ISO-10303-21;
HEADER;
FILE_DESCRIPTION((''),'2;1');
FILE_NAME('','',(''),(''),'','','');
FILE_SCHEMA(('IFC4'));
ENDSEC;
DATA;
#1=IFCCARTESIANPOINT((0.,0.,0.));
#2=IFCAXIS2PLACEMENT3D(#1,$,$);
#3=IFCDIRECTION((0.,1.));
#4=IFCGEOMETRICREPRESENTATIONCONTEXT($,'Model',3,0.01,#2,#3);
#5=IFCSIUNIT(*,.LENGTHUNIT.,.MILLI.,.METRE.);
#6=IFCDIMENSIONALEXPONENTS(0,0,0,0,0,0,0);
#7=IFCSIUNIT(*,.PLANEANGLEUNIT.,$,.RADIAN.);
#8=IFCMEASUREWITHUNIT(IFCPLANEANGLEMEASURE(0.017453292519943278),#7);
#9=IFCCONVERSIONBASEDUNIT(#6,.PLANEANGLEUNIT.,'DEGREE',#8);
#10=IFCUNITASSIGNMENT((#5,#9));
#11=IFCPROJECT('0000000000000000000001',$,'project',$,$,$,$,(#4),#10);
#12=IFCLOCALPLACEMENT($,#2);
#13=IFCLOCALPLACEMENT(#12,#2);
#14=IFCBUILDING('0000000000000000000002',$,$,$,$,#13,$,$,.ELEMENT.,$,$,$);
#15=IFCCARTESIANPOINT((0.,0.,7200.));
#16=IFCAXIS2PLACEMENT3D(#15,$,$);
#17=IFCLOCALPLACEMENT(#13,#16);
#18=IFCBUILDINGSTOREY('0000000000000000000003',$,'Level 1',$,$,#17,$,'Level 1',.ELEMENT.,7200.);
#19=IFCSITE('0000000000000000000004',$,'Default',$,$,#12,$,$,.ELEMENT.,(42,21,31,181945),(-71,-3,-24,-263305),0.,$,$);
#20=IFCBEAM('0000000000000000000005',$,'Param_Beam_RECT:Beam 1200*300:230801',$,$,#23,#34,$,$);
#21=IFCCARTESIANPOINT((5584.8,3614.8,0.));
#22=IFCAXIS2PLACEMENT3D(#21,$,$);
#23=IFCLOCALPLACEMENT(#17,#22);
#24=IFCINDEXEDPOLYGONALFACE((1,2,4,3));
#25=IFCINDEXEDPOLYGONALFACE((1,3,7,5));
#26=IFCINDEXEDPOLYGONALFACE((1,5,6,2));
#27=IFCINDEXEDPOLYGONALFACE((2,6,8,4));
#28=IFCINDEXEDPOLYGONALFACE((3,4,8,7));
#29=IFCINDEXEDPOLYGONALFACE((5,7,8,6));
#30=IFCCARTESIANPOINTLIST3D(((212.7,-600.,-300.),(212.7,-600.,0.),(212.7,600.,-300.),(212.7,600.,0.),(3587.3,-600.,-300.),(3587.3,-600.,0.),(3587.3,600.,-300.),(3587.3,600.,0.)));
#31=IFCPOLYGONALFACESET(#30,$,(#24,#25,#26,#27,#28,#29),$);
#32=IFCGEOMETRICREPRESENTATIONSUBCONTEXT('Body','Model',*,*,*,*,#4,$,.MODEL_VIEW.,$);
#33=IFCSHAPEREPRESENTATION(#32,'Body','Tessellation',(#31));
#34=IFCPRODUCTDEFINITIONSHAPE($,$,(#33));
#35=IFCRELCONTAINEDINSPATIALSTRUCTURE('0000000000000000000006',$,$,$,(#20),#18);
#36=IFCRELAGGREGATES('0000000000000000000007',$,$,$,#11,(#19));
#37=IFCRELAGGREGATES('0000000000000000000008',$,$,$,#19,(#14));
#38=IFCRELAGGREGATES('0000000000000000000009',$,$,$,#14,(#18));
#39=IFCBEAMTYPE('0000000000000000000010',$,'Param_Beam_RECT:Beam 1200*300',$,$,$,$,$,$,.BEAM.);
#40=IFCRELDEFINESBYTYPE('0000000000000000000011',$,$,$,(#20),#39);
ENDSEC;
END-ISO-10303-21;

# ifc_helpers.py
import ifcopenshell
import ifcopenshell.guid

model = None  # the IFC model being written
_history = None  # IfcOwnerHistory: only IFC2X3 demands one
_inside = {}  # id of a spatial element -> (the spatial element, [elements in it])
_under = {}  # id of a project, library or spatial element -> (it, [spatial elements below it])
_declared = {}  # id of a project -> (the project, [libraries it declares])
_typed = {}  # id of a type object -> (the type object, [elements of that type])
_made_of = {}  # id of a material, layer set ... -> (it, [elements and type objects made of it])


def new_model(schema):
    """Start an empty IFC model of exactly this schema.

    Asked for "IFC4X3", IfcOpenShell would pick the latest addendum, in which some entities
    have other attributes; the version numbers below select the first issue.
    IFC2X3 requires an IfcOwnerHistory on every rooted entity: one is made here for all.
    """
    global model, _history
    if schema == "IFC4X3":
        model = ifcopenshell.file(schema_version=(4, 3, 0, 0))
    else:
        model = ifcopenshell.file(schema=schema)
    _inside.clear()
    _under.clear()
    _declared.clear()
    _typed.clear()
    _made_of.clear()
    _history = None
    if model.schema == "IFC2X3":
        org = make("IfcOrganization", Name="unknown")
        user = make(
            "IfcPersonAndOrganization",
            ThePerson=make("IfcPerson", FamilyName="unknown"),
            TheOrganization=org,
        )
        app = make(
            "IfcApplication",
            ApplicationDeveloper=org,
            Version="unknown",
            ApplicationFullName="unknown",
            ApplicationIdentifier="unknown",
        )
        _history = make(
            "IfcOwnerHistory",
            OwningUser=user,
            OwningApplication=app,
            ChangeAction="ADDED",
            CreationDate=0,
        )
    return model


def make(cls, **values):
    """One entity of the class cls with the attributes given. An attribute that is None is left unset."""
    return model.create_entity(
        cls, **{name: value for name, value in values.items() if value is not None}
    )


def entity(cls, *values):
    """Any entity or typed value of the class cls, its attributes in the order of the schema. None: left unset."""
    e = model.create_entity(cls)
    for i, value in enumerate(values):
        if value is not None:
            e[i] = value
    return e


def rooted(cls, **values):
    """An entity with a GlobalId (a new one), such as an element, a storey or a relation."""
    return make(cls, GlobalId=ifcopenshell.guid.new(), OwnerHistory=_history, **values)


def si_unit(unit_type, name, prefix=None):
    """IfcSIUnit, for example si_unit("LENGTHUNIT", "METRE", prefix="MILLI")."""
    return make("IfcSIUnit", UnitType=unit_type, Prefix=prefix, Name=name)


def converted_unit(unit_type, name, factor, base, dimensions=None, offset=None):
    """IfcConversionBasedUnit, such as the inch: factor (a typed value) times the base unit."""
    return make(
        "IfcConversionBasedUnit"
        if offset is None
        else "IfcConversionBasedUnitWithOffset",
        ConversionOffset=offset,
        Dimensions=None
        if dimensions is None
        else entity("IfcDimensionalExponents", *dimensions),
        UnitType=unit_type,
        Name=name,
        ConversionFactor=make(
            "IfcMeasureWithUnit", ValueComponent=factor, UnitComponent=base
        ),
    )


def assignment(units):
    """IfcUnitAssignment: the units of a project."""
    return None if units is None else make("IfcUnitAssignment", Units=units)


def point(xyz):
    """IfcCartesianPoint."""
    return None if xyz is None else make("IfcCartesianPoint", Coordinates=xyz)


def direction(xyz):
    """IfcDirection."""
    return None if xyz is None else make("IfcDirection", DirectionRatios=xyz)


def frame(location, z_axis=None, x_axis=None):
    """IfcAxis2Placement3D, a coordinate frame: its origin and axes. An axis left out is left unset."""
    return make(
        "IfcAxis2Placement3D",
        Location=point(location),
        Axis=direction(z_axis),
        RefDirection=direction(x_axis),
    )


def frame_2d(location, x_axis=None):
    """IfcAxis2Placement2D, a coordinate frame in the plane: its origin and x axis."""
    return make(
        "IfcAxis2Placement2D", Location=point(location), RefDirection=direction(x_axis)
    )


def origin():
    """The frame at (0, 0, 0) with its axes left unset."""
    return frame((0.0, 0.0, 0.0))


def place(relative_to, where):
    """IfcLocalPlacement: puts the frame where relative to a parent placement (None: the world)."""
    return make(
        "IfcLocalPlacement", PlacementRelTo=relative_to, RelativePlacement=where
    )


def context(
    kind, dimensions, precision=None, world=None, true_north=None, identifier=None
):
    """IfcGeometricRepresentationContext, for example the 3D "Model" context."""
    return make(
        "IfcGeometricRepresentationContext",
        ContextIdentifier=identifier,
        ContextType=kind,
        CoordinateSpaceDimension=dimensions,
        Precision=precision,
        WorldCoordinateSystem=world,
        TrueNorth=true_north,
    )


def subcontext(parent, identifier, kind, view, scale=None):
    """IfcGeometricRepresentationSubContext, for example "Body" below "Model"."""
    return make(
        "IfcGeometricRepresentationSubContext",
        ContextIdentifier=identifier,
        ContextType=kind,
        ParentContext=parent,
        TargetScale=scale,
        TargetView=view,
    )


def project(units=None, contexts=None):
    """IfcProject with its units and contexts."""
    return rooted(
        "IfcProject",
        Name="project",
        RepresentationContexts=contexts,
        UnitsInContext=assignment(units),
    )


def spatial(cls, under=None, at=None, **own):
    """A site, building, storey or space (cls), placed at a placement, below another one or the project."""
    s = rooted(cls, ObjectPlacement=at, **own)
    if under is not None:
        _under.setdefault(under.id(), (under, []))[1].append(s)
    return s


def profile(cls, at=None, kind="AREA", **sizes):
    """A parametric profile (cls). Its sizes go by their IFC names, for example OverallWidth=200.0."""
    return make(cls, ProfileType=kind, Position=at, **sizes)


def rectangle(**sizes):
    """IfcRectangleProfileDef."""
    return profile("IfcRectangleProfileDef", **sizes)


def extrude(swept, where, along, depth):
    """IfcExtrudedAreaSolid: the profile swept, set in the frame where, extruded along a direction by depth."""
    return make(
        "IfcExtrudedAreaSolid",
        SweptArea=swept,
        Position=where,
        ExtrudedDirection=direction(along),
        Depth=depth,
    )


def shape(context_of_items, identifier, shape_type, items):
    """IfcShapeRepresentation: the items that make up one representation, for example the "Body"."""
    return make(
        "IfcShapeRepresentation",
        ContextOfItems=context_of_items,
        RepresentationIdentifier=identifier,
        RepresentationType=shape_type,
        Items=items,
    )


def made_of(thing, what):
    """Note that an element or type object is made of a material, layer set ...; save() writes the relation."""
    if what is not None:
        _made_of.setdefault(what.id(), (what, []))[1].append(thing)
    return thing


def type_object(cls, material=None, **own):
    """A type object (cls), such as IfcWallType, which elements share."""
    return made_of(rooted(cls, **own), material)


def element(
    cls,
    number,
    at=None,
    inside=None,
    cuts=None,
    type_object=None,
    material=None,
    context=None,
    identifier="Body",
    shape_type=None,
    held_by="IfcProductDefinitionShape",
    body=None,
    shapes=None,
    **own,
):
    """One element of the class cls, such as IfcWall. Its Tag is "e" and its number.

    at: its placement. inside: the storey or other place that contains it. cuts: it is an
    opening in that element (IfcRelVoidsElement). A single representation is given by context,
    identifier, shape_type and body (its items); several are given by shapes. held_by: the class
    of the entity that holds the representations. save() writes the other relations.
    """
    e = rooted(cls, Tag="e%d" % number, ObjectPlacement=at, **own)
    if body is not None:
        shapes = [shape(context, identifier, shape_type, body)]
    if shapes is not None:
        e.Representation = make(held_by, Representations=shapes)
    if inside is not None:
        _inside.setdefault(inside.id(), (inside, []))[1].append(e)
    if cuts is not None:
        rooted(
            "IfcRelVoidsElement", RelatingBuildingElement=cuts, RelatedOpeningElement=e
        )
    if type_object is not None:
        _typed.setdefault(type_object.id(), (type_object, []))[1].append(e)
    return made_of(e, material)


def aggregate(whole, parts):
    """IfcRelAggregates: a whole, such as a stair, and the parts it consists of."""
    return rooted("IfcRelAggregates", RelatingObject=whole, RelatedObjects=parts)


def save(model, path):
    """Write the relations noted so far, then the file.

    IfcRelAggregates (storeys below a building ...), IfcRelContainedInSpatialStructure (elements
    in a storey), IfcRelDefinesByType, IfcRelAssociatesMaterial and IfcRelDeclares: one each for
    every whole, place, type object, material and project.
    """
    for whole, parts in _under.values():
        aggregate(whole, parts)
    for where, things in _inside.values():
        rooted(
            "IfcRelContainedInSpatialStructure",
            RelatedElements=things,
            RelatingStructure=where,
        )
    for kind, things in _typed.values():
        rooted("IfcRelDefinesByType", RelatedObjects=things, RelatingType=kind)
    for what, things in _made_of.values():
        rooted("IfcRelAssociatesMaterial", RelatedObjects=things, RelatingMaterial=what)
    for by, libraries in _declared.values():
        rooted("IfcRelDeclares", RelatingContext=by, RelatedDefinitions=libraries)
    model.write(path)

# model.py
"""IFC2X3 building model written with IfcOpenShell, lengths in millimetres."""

from ifc_helpers import new_model, entity, si_unit, converted_unit, direction, frame, frame_2d, origin, place, context, subcontext, project, spatial, rectangle, extrude, type_object, element, save


model = new_model("IFC2X3")

# Units and contexts
model_context = context("Model", 3, precision=0.01, world=origin(), true_north=direction((0.0, 1.0)))
body_context = subcontext(model_context, "Body", "Model", "MODEL_VIEW")
ifc_project = project(units=[si_unit("LENGTHUNIT", "METRE", prefix="MILLI"), converted_unit("PLANEANGLEUNIT", "DEGREE", entity("IfcPlaneAngleMeasure", 0.017453292519943278), si_unit("PLANEANGLEUNIT", "RADIAN"), dimensions=[0, 0, 0, 0, 0, 0, 0])], contexts=[model_context])

# Site, building, storey
site_placement = place(None, origin())
site = spatial("IfcSite", under=ifc_project, at=site_placement, Name="Default", CompositionType="ELEMENT", RefLatitude=(42, 21, 31, 181945), RefLongitude=(-71, -3, -24, -263305), RefElevation=0.0)
building_placement = place(site_placement, origin())
building = spatial("IfcBuilding", under=site, at=building_placement, CompositionType="ELEMENT")
storey_placement = place(building_placement, frame((0.0, 0.0, 7200.0)))
storey = spatial("IfcBuildingStorey", under=building, at=storey_placement, Name="Level 1", LongName="Level 1", CompositionType="ELEMENT", Elevation=7200.0)

# Beam
beam_type_1 = type_object("IfcBeamType", Name="Param_Beam_RECT:Beam 1200*300", PredefinedType="BEAM")
beam_1_placement = place(storey_placement, frame((5584.8, 3614.8, 0.0)))
element("IfcBeam", 1, at=beam_1_placement, inside=storey, type_object=beam_type_1, Name="Param_Beam_RECT:Beam 1200*300:230801", context=body_context, shape_type="SweptSolid", body=[
    extrude(rectangle(XDim=300.0, YDim=1200.0, at=frame_2d((0.0, 0.0), x_axis=(1.0, 0.0))), frame((212.7, 0.0, -150.0), z_axis=(1.0, 0.0, 0.0), x_axis=(0.0, 0.0, -1.0)), (0.0, 0.0, 1.0), 3374.6),
])

save(model, "model.ifc")
